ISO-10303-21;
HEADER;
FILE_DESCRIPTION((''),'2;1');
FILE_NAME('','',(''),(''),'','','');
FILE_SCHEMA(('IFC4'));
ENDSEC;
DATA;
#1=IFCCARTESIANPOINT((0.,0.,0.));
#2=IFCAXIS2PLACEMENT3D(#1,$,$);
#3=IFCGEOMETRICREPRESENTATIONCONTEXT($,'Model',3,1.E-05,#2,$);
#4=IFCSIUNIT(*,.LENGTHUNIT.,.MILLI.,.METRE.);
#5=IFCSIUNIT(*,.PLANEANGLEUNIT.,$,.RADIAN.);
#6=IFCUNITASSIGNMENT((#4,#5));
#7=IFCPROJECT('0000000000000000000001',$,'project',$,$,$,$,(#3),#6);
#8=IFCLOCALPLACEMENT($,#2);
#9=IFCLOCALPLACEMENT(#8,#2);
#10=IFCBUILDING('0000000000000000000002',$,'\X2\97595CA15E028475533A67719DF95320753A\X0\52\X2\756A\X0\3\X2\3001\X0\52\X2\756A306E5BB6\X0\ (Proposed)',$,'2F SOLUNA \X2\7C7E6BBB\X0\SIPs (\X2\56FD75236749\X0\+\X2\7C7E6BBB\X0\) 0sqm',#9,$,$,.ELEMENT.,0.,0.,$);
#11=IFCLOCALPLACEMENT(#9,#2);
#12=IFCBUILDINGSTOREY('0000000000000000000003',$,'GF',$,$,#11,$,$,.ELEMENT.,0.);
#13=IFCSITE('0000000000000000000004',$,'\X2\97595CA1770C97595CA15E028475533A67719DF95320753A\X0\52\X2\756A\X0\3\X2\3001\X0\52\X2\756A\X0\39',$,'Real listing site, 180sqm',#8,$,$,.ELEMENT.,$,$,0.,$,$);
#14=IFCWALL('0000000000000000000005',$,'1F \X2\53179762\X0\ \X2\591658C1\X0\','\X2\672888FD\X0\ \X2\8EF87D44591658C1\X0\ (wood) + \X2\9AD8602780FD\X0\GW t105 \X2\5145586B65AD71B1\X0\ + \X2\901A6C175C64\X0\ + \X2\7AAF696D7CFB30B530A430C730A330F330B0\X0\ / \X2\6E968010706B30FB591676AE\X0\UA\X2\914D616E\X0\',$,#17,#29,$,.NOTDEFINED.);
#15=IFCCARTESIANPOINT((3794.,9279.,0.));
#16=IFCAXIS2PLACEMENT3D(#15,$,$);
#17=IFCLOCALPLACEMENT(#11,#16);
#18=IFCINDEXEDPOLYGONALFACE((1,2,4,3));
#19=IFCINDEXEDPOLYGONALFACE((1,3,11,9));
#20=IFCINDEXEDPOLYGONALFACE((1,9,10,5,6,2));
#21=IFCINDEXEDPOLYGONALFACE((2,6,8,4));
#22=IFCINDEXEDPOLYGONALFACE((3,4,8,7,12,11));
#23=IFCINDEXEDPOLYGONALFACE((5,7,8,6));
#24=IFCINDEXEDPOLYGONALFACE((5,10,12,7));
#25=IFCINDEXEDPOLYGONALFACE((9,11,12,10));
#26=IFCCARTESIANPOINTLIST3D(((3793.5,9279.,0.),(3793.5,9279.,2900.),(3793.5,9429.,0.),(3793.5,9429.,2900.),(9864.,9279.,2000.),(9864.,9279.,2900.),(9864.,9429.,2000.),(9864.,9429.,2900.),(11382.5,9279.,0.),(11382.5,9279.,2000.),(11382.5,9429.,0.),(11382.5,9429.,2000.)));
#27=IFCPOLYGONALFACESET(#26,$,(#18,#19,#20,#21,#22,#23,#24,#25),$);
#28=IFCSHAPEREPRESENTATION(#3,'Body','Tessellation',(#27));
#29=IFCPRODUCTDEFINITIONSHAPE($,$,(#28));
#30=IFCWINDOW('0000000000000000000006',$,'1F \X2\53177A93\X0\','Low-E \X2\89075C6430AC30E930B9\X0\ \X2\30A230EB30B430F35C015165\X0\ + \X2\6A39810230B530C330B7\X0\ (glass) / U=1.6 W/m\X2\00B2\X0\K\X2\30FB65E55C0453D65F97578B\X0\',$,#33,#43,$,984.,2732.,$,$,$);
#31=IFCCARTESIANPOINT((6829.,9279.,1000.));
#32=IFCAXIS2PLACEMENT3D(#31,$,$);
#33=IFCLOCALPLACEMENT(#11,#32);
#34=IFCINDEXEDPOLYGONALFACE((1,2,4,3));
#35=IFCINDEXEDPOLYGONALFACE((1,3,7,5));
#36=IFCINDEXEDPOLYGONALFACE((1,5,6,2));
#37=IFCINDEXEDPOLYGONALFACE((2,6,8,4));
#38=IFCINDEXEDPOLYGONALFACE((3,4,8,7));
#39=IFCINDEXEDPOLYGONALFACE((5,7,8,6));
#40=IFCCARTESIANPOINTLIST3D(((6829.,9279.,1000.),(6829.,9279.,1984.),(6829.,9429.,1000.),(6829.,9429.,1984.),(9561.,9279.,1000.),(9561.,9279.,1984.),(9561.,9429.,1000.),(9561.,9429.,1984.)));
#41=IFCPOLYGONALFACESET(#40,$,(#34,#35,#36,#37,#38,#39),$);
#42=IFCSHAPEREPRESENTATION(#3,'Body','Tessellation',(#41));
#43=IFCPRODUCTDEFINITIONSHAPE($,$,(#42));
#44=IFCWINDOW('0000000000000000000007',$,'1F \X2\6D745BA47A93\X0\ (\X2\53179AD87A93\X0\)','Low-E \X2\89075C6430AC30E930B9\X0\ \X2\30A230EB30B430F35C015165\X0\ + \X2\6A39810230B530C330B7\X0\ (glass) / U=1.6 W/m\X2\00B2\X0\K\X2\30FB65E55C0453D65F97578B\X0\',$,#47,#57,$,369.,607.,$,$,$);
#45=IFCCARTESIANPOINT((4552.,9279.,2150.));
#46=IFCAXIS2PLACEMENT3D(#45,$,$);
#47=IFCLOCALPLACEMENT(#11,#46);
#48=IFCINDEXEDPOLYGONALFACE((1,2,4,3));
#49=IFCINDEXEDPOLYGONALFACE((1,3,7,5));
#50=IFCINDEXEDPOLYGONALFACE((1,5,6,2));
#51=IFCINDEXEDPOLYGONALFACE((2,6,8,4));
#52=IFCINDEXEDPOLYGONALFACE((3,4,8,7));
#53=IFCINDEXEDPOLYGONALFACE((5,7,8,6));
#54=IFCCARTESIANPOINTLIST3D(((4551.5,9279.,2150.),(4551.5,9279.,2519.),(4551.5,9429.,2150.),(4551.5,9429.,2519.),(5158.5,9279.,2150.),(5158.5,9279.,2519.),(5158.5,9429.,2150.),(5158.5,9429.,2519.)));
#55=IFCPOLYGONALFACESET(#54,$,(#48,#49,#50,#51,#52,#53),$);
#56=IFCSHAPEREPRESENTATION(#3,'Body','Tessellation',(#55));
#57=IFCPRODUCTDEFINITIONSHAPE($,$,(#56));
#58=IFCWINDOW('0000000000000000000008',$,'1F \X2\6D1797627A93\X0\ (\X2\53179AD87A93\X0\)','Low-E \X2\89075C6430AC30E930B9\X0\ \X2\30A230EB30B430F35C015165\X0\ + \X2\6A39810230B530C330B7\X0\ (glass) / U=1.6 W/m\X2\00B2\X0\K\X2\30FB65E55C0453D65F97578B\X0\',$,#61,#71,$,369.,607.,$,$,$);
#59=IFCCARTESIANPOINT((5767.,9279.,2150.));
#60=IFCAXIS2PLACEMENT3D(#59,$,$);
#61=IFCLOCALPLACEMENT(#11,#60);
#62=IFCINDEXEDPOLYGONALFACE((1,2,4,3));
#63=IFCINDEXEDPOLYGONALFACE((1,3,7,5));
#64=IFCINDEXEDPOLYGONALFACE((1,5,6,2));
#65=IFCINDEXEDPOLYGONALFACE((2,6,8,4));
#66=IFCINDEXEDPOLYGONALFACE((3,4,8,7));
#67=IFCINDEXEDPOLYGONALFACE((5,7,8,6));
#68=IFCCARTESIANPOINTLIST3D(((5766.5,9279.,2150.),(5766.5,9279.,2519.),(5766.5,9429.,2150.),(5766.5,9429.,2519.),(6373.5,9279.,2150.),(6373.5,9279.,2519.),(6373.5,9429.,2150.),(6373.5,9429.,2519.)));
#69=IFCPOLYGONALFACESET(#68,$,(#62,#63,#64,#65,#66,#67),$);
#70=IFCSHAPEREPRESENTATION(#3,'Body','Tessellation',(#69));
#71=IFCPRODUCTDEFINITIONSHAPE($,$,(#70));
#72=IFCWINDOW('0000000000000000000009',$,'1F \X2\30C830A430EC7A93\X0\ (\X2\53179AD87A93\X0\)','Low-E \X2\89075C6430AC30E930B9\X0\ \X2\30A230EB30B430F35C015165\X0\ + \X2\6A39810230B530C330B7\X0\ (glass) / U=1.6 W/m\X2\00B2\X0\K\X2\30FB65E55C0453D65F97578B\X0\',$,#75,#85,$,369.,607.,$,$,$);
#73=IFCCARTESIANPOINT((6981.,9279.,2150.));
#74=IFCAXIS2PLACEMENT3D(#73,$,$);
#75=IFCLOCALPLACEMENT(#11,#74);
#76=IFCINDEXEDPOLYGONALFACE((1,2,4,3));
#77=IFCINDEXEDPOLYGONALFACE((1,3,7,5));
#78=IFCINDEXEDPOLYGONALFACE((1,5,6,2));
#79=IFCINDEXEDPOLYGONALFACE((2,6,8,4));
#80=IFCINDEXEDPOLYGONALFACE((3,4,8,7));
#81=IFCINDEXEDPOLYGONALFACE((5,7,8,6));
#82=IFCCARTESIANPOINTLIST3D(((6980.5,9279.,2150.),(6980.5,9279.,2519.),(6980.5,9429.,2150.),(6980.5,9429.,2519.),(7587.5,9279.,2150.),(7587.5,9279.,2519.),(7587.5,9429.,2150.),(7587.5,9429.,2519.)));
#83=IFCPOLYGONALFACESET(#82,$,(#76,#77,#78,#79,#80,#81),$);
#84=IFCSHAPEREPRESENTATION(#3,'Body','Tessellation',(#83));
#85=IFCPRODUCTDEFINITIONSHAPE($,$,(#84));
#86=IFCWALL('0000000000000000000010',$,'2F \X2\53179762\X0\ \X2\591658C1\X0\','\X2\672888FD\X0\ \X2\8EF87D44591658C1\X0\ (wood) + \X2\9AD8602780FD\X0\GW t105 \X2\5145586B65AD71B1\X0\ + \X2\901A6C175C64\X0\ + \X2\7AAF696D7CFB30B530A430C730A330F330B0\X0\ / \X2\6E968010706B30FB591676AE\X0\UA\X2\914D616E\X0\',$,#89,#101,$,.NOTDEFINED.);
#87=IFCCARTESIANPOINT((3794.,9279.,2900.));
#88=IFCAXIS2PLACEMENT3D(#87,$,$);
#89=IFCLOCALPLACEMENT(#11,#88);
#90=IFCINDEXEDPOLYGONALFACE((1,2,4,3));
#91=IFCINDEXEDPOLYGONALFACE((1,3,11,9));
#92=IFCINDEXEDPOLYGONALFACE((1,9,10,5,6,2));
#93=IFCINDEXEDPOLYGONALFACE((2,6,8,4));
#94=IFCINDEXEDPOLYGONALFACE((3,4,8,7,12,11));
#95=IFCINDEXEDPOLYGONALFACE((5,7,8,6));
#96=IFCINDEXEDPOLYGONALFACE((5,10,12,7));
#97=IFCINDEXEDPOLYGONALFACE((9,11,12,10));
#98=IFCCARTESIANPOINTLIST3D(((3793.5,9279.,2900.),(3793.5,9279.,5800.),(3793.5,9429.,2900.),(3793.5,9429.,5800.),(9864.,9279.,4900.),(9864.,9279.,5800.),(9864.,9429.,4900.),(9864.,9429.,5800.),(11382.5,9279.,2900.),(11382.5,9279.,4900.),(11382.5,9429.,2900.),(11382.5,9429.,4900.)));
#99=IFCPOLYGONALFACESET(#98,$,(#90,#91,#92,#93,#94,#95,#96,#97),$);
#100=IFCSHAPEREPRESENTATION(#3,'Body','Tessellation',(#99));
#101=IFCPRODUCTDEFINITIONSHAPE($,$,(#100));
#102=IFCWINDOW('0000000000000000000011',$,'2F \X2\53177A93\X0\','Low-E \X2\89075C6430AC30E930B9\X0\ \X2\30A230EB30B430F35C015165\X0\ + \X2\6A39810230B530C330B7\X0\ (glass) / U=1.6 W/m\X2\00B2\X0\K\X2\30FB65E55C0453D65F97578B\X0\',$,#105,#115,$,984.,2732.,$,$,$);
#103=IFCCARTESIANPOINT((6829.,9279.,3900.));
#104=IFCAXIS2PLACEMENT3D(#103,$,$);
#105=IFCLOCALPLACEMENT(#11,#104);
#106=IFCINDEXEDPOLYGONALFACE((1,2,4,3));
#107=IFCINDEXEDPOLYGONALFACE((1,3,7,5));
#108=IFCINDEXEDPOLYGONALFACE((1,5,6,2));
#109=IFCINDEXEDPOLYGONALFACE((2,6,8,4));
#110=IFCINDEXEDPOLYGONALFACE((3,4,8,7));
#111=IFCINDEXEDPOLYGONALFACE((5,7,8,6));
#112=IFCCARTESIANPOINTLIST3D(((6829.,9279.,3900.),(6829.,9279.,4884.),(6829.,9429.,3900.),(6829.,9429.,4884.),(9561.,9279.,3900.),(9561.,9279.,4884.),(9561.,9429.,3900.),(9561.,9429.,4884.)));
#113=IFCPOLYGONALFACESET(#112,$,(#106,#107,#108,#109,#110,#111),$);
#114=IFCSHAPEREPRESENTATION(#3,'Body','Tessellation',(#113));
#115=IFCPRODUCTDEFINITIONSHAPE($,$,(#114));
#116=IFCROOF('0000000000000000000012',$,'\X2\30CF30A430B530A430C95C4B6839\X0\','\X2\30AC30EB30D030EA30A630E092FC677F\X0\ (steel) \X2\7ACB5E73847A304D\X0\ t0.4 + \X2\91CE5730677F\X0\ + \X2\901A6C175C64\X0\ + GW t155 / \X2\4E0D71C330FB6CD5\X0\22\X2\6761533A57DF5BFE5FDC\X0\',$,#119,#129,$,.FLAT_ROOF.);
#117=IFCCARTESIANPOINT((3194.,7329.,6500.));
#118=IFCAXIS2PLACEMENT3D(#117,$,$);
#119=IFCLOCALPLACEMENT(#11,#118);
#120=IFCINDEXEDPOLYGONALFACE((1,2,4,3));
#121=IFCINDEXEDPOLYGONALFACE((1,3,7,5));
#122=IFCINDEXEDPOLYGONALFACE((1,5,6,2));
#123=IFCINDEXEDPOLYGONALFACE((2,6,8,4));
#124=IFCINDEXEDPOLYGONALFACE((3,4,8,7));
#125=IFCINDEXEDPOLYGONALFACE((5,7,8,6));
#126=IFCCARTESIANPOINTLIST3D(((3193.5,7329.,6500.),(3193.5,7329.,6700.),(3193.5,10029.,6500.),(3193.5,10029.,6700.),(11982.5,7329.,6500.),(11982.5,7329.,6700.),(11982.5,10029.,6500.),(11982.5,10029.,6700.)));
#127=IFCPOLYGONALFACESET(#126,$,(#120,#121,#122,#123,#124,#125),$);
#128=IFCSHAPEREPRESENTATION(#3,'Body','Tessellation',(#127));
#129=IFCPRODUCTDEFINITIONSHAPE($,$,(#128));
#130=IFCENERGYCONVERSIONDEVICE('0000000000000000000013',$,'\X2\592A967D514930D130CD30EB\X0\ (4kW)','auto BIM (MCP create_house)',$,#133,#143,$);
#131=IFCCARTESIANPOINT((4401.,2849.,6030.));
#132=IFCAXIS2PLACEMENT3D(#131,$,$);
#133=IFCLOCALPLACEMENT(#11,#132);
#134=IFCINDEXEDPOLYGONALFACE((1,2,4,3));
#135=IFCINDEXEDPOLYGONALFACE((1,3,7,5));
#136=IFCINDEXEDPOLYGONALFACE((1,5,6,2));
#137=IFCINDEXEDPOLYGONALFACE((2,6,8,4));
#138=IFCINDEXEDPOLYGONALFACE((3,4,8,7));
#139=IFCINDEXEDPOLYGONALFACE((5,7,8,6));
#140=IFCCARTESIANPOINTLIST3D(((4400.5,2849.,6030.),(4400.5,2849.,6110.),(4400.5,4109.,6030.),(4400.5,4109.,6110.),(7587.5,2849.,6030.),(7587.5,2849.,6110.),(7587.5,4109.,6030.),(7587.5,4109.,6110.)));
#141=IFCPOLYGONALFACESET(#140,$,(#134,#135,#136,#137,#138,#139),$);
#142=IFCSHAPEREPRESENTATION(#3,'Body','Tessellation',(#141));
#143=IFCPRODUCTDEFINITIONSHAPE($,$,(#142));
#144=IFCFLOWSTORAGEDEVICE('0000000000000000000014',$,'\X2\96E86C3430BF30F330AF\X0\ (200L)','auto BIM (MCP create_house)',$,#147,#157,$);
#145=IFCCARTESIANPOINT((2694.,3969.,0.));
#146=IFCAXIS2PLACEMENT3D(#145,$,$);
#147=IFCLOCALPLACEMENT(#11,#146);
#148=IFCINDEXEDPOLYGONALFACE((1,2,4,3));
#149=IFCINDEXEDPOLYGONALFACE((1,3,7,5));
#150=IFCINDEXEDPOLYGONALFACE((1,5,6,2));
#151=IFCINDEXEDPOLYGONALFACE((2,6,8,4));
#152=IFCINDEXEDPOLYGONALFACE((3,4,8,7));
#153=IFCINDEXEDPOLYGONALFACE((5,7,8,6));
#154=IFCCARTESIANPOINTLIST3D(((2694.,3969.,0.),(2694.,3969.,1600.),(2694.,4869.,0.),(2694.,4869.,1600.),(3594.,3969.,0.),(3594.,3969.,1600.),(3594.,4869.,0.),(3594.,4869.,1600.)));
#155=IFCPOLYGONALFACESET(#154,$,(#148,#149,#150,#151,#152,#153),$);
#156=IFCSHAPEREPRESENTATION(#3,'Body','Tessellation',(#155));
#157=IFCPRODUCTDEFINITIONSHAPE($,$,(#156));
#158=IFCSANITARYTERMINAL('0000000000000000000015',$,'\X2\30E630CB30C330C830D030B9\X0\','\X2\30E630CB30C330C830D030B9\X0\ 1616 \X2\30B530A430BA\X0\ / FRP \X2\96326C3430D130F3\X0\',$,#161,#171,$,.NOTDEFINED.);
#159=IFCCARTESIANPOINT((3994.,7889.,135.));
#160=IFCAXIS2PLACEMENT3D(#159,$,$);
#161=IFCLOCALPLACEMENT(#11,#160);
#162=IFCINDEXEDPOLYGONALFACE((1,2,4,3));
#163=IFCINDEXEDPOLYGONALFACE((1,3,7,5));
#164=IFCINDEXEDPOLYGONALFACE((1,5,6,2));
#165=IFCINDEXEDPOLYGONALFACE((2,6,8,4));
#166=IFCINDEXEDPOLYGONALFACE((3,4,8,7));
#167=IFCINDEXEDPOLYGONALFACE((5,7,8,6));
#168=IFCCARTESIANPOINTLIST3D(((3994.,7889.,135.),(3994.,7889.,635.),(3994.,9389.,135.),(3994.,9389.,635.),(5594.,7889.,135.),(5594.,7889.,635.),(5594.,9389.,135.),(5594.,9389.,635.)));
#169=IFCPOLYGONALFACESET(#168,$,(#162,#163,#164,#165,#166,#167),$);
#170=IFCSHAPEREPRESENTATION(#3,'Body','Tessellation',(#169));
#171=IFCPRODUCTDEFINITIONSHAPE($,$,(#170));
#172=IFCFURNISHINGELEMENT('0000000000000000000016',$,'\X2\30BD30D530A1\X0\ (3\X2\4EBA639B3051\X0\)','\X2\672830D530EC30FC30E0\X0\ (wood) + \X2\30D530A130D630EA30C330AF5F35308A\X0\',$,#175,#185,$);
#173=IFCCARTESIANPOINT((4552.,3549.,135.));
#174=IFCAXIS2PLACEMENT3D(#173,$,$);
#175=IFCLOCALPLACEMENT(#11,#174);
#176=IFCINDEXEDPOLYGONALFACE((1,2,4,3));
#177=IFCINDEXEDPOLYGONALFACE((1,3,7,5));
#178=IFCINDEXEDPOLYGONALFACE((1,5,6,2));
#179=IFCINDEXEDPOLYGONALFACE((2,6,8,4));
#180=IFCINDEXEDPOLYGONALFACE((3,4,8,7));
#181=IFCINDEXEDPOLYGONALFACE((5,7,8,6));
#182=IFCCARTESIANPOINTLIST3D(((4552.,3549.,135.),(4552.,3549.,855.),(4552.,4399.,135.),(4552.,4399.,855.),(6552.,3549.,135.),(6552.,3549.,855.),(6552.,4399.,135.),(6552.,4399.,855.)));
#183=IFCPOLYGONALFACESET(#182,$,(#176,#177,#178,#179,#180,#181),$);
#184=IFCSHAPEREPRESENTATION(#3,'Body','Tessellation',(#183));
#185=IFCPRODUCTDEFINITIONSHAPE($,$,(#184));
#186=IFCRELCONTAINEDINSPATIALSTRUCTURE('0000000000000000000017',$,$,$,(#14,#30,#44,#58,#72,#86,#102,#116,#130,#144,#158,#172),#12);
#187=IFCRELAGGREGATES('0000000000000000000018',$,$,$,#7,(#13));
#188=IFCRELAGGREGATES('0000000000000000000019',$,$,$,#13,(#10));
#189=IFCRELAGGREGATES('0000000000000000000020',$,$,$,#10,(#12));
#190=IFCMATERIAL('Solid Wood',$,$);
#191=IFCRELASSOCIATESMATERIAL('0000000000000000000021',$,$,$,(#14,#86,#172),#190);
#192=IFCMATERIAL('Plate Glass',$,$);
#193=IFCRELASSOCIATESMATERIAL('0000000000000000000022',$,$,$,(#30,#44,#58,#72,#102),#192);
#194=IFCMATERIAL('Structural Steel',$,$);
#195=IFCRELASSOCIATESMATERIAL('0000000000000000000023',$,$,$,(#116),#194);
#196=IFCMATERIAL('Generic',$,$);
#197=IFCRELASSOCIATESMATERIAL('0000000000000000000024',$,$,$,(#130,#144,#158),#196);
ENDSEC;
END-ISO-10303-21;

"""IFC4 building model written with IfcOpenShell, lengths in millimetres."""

from ifc_helpers import new_model, si_unit, frame, frame_2d, origin, place, context, project, spatial, rectangle, extrude, material, element, fill, save


model = new_model("IFC4")

# Units and contexts
model_context = context("Model", 3, precision=1e-05, world=origin())
ifc_project = project(units=[si_unit("LENGTHUNIT", "METRE", prefix="MILLI"), si_unit("PLANEANGLEUNIT", "RADIAN")], contexts=[model_context])

# Site, building, storey
site_placement = place(None, origin())
site = spatial("IfcSite", under=ifc_project, at=site_placement, Name="静岡県静岡市葵区東鷹匠町52番3、52番39", ObjectType="Real listing site, 180sqm", CompositionType="ELEMENT", RefElevation=0.0)
building_placement = place(site_placement, origin())
building = spatial("IfcBuilding", under=site, at=building_placement, Name="静岡市葵区東鷹匠町52番3、52番の家 (Proposed)", ObjectType="2F SOLUNA 籾殻SIPs (国産杉+籾殻) 0sqm", CompositionType="ELEMENT", ElevationOfRefHeight=0.0, ElevationOfTerrain=0.0)
storey_placement = place(building_placement, origin())
storey = spatial("IfcBuildingStorey", under=building, at=storey_placement, Name="GF", CompositionType="ELEMENT", Elevation=0.0)

# Wall, openings, windows
ifc_material_1 = material(Name="Solid Wood")
wall_1_placement = place(storey_placement, frame((3794.0, 9279.0, 0.0)))
wall_1 = element("IfcWall", 1, at=wall_1_placement, inside=storey, material=ifc_material_1, Name="1F 北面 外壁", Description="木製 軸組外壁 (wood) + 高性能GW t105 充填断熱 + 通気層 + 窯業系サイディング / 準耐火・外皮UA配慮", PredefinedType="NOTDEFINED", context=model_context, shape_type="SweptSolid", body=[
    extrude(rectangle(XDim=7589.0, YDim=150.0, at=frame_2d((3794.0, 75.0))), frame((3794.0, 9279.0, 0.0)), (0.0, 0.0, 1.0), 2900.0),
])
opening_1_placement = place(storey_placement, frame((6829.0, 9279.0, 1000.0)))
opening_1 = element("IfcOpeningElement", 2, at=opening_1_placement, cuts=wall_1, PredefinedType="NOTDEFINED", context=model_context, shape_type="SweptSolid", body=[
    extrude(rectangle(XDim=2732.0, YDim=150.0, at=frame_2d((1366.0, 75.0))), frame((6829.0, 9279.0, 1000.0)), (0.0, 0.0, 1.0), 984.0),
])
opening_2_placement = place(storey_placement, frame((4552.0, 9279.0, 2150.0)))
opening_2 = element("IfcOpeningElement", 3, at=opening_2_placement, cuts=wall_1, PredefinedType="NOTDEFINED", context=model_context, shape_type="SweptSolid", body=[
    extrude(rectangle(XDim=607.0, YDim=150.0, at=frame_2d((303.0, 75.0))), frame((4552.0, 9279.0, 2150.0)), (0.0, 0.0, 1.0), 369.0),
])
opening_3_placement = place(storey_placement, frame((5767.0, 9279.0, 2150.0)))
opening_3 = element("IfcOpeningElement", 4, at=opening_3_placement, cuts=wall_1, PredefinedType="NOTDEFINED", context=model_context, shape_type="SweptSolid", body=[
    extrude(rectangle(XDim=607.0, YDim=150.0, at=frame_2d((303.0, 75.0))), frame((5767.0, 9279.0, 2150.0)), (0.0, 0.0, 1.0), 369.0),
])
opening_4_placement = place(storey_placement, frame((6981.0, 9279.0, 2150.0)))
opening_4 = element("IfcOpeningElement", 5, at=opening_4_placement, cuts=wall_1, PredefinedType="NOTDEFINED", context=model_context, shape_type="SweptSolid", body=[
    extrude(rectangle(XDim=607.0, YDim=150.0, at=frame_2d((303.0, 75.0))), frame((6981.0, 9279.0, 2150.0)), (0.0, 0.0, 1.0), 369.0),
])
ifc_material_2 = material(Name="Plate Glass")
window_1_placement = place(storey_placement, frame((6829.0, 9279.0, 1000.0)))
window_1 = element("IfcWindow", 6, at=window_1_placement, inside=storey, material=ifc_material_2, Name="1F 北窓", Description="Low-E 複層ガラス アルゴン封入 + 樹脂サッシ (glass) / U=1.6 W/m²K・日射取得型", OverallHeight=984.0, OverallWidth=2732.0, context=model_context, shape_type="SweptSolid", body=[
    extrude(rectangle(XDim=2732.0, YDim=150.0, at=frame_2d((1366.0, 75.0))), frame((6829.0, 9279.0, 1000.0)), (0.0, 0.0, 1.0), 984.0),
])
fill(opening_1, window_1)
window_2_placement = place(storey_placement, frame((4552.0, 9279.0, 2150.0)))
window_2 = element("IfcWindow", 7, at=window_2_placement, inside=storey, material=ifc_material_2, Name="1F 浴室窓 (北高窓)", Description="Low-E 複層ガラス アルゴン封入 + 樹脂サッシ (glass) / U=1.6 W/m²K・日射取得型", OverallHeight=369.0, OverallWidth=607.0, context=model_context, shape_type="SweptSolid", body=[
    extrude(rectangle(XDim=607.0, YDim=150.0, at=frame_2d((303.0, 75.0))), frame((4552.0, 9279.0, 2150.0)), (0.0, 0.0, 1.0), 369.0),
])
fill(opening_2, window_2)
window_3_placement = place(storey_placement, frame((5767.0, 9279.0, 2150.0)))
window_3 = element("IfcWindow", 8, at=window_3_placement, inside=storey, material=ifc_material_2, Name="1F 洗面窓 (北高窓)", Description="Low-E 複層ガラス アルゴン封入 + 樹脂サッシ (glass) / U=1.6 W/m²K・日射取得型", OverallHeight=369.0, OverallWidth=607.0, context=model_context, shape_type="SweptSolid", body=[
    extrude(rectangle(XDim=607.0, YDim=150.0, at=frame_2d((303.0, 75.0))), frame((5767.0, 9279.0, 2150.0)), (0.0, 0.0, 1.0), 369.0),
])
fill(opening_3, window_3)
window_4_placement = place(storey_placement, frame((6981.0, 9279.0, 2150.0)))
window_4 = element("IfcWindow", 9, at=window_4_placement, inside=storey, material=ifc_material_2, Name="1F トイレ窓 (北高窓)", Description="Low-E 複層ガラス アルゴン封入 + 樹脂サッシ (glass) / U=1.6 W/m²K・日射取得型", OverallHeight=369.0, OverallWidth=607.0, context=model_context, shape_type="SweptSolid", body=[
    extrude(rectangle(XDim=607.0, YDim=150.0, at=frame_2d((303.0, 75.0))), frame((6981.0, 9279.0, 2150.0)), (0.0, 0.0, 1.0), 369.0),
])
fill(opening_4, window_4)

# Wall, opening, window
wall_2_placement = place(storey_placement, frame((3794.0, 9279.0, 2900.0)))
wall_2 = element("IfcWall", 10, at=wall_2_placement, inside=storey, material=ifc_material_1, Name="2F 北面 外壁", Description="木製 軸組外壁 (wood) + 高性能GW t105 充填断熱 + 通気層 + 窯業系サイディング / 準耐火・外皮UA配慮", PredefinedType="NOTDEFINED", context=model_context, shape_type="SweptSolid", body=[
    extrude(rectangle(XDim=7589.0, YDim=150.0, at=frame_2d((3794.0, 75.0))), frame((3794.0, 9279.0, 2900.0)), (0.0, 0.0, 1.0), 2900.0),
])
opening_5_placement = place(storey_placement, frame((6829.0, 9279.0, 3900.0)))
opening_5 = element("IfcOpeningElement", 11, at=opening_5_placement, cuts=wall_2, PredefinedType="NOTDEFINED", context=model_context, shape_type="SweptSolid", body=[
    extrude(rectangle(XDim=2732.0, YDim=150.0, at=frame_2d((1366.0, 75.0))), frame((6829.0, 9279.0, 3900.0)), (0.0, 0.0, 1.0), 984.0),
])
window_5_placement = place(storey_placement, frame((6829.0, 9279.0, 3900.0)))
window_5 = element("IfcWindow", 12, at=window_5_placement, inside=storey, material=ifc_material_2, Name="2F 北窓", Description="Low-E 複層ガラス アルゴン封入 + 樹脂サッシ (glass) / U=1.6 W/m²K・日射取得型", OverallHeight=984.0, OverallWidth=2732.0, context=model_context, shape_type="SweptSolid", body=[
    extrude(rectangle(XDim=2732.0, YDim=150.0, at=frame_2d((1366.0, 75.0))), frame((6829.0, 9279.0, 3900.0)), (0.0, 0.0, 1.0), 984.0),
])
fill(opening_5, window_5)

# Roof
ifc_material_3 = material(Name="Structural Steel")
roof_placement = place(storey_placement, frame((3194.0, 7329.0, 6500.0)))
element("IfcRoof", 13, at=roof_placement, inside=storey, material=ifc_material_3, Name="ハイサイド屋根", Description="ガルバリウム鋼板 (steel) 立平葺き t0.4 + 野地板 + 通気層 + GW t155 / 不燃・法22条区域対応", PredefinedType="FLAT_ROOF", context=model_context, shape_type="SweptSolid", body=[
    extrude(rectangle(XDim=8789.0, YDim=2700.0, at=frame_2d((4394.0, 1350.0))), frame((3194.0, 7329.0, 6500.0)), (0.0, 0.0, 1.0), 200.0),
])

# Energy conversion device
ifc_material_4 = material(Name="Generic")
energy_conversion_device_placement = place(storey_placement, frame((4401.0, 2849.0, 6030.0)))
element("IfcEnergyConversionDevice", 14, at=energy_conversion_device_placement, inside=storey, material=ifc_material_4, Name="太陽光パネル (4kW)", Description="auto BIM (MCP create_house)", context=model_context, shape_type="SweptSolid", body=[
    extrude(rectangle(XDim=3187.0, YDim=1260.0, at=frame_2d((1593.0, 630.0))), frame((4401.0, 2849.0, 6030.0)), (0.0, 0.0, 1.0), 80.0),
])

# Flow storage device
flow_storage_device_placement = place(storey_placement, frame((2694.0, 3969.0, 0.0)))
element("IfcFlowStorageDevice", 15, at=flow_storage_device_placement, inside=storey, material=ifc_material_4, Name="雨水タンク (200L)", Description="auto BIM (MCP create_house)", context=model_context, shape_type="SweptSolid", body=[
    extrude(rectangle(XDim=900.0, YDim=900.0, at=frame_2d((450.0, 450.0))), frame((2694.0, 3969.0, 0.0)), (0.0, 0.0, 1.0), 1600.0),
])

# Sanitary terminal
sanitary_terminal_placement = place(storey_placement, frame((3994.0, 7889.0, 135.0)))
element("IfcSanitaryTerminal", 16, at=sanitary_terminal_placement, inside=storey, material=ifc_material_4, Name="ユニットバス", Description="ユニットバス 1616 サイズ / FRP 防水パン", PredefinedType="NOTDEFINED", context=model_context, shape_type="SweptSolid", body=[
    extrude(rectangle(XDim=1600.0, YDim=1500.0, at=frame_2d((800.0, 750.0))), frame((3994.0, 7889.0, 135.0)), (0.0, 0.0, 1.0), 500.0),
])

# Furnishing element
furnishing_1_placement = place(storey_placement, frame((4552.0, 3549.0, 135.0)))
element("IfcFurnishingElement", 17, at=furnishing_1_placement, inside=storey, material=ifc_material_1, Name="ソファ (3人掛け)", Description="木フレーム (wood) + ファブリック張り", context=model_context, shape_type="SweptSolid", body=[
    extrude(rectangle(XDim=2000.0, YDim=850.0, at=frame_2d((1000.0, 425.0))), frame((4552.0, 3549.0, 135.0)), (0.0, 0.0, 1.0), 720.0),
])

save(model, "model.ifc")
